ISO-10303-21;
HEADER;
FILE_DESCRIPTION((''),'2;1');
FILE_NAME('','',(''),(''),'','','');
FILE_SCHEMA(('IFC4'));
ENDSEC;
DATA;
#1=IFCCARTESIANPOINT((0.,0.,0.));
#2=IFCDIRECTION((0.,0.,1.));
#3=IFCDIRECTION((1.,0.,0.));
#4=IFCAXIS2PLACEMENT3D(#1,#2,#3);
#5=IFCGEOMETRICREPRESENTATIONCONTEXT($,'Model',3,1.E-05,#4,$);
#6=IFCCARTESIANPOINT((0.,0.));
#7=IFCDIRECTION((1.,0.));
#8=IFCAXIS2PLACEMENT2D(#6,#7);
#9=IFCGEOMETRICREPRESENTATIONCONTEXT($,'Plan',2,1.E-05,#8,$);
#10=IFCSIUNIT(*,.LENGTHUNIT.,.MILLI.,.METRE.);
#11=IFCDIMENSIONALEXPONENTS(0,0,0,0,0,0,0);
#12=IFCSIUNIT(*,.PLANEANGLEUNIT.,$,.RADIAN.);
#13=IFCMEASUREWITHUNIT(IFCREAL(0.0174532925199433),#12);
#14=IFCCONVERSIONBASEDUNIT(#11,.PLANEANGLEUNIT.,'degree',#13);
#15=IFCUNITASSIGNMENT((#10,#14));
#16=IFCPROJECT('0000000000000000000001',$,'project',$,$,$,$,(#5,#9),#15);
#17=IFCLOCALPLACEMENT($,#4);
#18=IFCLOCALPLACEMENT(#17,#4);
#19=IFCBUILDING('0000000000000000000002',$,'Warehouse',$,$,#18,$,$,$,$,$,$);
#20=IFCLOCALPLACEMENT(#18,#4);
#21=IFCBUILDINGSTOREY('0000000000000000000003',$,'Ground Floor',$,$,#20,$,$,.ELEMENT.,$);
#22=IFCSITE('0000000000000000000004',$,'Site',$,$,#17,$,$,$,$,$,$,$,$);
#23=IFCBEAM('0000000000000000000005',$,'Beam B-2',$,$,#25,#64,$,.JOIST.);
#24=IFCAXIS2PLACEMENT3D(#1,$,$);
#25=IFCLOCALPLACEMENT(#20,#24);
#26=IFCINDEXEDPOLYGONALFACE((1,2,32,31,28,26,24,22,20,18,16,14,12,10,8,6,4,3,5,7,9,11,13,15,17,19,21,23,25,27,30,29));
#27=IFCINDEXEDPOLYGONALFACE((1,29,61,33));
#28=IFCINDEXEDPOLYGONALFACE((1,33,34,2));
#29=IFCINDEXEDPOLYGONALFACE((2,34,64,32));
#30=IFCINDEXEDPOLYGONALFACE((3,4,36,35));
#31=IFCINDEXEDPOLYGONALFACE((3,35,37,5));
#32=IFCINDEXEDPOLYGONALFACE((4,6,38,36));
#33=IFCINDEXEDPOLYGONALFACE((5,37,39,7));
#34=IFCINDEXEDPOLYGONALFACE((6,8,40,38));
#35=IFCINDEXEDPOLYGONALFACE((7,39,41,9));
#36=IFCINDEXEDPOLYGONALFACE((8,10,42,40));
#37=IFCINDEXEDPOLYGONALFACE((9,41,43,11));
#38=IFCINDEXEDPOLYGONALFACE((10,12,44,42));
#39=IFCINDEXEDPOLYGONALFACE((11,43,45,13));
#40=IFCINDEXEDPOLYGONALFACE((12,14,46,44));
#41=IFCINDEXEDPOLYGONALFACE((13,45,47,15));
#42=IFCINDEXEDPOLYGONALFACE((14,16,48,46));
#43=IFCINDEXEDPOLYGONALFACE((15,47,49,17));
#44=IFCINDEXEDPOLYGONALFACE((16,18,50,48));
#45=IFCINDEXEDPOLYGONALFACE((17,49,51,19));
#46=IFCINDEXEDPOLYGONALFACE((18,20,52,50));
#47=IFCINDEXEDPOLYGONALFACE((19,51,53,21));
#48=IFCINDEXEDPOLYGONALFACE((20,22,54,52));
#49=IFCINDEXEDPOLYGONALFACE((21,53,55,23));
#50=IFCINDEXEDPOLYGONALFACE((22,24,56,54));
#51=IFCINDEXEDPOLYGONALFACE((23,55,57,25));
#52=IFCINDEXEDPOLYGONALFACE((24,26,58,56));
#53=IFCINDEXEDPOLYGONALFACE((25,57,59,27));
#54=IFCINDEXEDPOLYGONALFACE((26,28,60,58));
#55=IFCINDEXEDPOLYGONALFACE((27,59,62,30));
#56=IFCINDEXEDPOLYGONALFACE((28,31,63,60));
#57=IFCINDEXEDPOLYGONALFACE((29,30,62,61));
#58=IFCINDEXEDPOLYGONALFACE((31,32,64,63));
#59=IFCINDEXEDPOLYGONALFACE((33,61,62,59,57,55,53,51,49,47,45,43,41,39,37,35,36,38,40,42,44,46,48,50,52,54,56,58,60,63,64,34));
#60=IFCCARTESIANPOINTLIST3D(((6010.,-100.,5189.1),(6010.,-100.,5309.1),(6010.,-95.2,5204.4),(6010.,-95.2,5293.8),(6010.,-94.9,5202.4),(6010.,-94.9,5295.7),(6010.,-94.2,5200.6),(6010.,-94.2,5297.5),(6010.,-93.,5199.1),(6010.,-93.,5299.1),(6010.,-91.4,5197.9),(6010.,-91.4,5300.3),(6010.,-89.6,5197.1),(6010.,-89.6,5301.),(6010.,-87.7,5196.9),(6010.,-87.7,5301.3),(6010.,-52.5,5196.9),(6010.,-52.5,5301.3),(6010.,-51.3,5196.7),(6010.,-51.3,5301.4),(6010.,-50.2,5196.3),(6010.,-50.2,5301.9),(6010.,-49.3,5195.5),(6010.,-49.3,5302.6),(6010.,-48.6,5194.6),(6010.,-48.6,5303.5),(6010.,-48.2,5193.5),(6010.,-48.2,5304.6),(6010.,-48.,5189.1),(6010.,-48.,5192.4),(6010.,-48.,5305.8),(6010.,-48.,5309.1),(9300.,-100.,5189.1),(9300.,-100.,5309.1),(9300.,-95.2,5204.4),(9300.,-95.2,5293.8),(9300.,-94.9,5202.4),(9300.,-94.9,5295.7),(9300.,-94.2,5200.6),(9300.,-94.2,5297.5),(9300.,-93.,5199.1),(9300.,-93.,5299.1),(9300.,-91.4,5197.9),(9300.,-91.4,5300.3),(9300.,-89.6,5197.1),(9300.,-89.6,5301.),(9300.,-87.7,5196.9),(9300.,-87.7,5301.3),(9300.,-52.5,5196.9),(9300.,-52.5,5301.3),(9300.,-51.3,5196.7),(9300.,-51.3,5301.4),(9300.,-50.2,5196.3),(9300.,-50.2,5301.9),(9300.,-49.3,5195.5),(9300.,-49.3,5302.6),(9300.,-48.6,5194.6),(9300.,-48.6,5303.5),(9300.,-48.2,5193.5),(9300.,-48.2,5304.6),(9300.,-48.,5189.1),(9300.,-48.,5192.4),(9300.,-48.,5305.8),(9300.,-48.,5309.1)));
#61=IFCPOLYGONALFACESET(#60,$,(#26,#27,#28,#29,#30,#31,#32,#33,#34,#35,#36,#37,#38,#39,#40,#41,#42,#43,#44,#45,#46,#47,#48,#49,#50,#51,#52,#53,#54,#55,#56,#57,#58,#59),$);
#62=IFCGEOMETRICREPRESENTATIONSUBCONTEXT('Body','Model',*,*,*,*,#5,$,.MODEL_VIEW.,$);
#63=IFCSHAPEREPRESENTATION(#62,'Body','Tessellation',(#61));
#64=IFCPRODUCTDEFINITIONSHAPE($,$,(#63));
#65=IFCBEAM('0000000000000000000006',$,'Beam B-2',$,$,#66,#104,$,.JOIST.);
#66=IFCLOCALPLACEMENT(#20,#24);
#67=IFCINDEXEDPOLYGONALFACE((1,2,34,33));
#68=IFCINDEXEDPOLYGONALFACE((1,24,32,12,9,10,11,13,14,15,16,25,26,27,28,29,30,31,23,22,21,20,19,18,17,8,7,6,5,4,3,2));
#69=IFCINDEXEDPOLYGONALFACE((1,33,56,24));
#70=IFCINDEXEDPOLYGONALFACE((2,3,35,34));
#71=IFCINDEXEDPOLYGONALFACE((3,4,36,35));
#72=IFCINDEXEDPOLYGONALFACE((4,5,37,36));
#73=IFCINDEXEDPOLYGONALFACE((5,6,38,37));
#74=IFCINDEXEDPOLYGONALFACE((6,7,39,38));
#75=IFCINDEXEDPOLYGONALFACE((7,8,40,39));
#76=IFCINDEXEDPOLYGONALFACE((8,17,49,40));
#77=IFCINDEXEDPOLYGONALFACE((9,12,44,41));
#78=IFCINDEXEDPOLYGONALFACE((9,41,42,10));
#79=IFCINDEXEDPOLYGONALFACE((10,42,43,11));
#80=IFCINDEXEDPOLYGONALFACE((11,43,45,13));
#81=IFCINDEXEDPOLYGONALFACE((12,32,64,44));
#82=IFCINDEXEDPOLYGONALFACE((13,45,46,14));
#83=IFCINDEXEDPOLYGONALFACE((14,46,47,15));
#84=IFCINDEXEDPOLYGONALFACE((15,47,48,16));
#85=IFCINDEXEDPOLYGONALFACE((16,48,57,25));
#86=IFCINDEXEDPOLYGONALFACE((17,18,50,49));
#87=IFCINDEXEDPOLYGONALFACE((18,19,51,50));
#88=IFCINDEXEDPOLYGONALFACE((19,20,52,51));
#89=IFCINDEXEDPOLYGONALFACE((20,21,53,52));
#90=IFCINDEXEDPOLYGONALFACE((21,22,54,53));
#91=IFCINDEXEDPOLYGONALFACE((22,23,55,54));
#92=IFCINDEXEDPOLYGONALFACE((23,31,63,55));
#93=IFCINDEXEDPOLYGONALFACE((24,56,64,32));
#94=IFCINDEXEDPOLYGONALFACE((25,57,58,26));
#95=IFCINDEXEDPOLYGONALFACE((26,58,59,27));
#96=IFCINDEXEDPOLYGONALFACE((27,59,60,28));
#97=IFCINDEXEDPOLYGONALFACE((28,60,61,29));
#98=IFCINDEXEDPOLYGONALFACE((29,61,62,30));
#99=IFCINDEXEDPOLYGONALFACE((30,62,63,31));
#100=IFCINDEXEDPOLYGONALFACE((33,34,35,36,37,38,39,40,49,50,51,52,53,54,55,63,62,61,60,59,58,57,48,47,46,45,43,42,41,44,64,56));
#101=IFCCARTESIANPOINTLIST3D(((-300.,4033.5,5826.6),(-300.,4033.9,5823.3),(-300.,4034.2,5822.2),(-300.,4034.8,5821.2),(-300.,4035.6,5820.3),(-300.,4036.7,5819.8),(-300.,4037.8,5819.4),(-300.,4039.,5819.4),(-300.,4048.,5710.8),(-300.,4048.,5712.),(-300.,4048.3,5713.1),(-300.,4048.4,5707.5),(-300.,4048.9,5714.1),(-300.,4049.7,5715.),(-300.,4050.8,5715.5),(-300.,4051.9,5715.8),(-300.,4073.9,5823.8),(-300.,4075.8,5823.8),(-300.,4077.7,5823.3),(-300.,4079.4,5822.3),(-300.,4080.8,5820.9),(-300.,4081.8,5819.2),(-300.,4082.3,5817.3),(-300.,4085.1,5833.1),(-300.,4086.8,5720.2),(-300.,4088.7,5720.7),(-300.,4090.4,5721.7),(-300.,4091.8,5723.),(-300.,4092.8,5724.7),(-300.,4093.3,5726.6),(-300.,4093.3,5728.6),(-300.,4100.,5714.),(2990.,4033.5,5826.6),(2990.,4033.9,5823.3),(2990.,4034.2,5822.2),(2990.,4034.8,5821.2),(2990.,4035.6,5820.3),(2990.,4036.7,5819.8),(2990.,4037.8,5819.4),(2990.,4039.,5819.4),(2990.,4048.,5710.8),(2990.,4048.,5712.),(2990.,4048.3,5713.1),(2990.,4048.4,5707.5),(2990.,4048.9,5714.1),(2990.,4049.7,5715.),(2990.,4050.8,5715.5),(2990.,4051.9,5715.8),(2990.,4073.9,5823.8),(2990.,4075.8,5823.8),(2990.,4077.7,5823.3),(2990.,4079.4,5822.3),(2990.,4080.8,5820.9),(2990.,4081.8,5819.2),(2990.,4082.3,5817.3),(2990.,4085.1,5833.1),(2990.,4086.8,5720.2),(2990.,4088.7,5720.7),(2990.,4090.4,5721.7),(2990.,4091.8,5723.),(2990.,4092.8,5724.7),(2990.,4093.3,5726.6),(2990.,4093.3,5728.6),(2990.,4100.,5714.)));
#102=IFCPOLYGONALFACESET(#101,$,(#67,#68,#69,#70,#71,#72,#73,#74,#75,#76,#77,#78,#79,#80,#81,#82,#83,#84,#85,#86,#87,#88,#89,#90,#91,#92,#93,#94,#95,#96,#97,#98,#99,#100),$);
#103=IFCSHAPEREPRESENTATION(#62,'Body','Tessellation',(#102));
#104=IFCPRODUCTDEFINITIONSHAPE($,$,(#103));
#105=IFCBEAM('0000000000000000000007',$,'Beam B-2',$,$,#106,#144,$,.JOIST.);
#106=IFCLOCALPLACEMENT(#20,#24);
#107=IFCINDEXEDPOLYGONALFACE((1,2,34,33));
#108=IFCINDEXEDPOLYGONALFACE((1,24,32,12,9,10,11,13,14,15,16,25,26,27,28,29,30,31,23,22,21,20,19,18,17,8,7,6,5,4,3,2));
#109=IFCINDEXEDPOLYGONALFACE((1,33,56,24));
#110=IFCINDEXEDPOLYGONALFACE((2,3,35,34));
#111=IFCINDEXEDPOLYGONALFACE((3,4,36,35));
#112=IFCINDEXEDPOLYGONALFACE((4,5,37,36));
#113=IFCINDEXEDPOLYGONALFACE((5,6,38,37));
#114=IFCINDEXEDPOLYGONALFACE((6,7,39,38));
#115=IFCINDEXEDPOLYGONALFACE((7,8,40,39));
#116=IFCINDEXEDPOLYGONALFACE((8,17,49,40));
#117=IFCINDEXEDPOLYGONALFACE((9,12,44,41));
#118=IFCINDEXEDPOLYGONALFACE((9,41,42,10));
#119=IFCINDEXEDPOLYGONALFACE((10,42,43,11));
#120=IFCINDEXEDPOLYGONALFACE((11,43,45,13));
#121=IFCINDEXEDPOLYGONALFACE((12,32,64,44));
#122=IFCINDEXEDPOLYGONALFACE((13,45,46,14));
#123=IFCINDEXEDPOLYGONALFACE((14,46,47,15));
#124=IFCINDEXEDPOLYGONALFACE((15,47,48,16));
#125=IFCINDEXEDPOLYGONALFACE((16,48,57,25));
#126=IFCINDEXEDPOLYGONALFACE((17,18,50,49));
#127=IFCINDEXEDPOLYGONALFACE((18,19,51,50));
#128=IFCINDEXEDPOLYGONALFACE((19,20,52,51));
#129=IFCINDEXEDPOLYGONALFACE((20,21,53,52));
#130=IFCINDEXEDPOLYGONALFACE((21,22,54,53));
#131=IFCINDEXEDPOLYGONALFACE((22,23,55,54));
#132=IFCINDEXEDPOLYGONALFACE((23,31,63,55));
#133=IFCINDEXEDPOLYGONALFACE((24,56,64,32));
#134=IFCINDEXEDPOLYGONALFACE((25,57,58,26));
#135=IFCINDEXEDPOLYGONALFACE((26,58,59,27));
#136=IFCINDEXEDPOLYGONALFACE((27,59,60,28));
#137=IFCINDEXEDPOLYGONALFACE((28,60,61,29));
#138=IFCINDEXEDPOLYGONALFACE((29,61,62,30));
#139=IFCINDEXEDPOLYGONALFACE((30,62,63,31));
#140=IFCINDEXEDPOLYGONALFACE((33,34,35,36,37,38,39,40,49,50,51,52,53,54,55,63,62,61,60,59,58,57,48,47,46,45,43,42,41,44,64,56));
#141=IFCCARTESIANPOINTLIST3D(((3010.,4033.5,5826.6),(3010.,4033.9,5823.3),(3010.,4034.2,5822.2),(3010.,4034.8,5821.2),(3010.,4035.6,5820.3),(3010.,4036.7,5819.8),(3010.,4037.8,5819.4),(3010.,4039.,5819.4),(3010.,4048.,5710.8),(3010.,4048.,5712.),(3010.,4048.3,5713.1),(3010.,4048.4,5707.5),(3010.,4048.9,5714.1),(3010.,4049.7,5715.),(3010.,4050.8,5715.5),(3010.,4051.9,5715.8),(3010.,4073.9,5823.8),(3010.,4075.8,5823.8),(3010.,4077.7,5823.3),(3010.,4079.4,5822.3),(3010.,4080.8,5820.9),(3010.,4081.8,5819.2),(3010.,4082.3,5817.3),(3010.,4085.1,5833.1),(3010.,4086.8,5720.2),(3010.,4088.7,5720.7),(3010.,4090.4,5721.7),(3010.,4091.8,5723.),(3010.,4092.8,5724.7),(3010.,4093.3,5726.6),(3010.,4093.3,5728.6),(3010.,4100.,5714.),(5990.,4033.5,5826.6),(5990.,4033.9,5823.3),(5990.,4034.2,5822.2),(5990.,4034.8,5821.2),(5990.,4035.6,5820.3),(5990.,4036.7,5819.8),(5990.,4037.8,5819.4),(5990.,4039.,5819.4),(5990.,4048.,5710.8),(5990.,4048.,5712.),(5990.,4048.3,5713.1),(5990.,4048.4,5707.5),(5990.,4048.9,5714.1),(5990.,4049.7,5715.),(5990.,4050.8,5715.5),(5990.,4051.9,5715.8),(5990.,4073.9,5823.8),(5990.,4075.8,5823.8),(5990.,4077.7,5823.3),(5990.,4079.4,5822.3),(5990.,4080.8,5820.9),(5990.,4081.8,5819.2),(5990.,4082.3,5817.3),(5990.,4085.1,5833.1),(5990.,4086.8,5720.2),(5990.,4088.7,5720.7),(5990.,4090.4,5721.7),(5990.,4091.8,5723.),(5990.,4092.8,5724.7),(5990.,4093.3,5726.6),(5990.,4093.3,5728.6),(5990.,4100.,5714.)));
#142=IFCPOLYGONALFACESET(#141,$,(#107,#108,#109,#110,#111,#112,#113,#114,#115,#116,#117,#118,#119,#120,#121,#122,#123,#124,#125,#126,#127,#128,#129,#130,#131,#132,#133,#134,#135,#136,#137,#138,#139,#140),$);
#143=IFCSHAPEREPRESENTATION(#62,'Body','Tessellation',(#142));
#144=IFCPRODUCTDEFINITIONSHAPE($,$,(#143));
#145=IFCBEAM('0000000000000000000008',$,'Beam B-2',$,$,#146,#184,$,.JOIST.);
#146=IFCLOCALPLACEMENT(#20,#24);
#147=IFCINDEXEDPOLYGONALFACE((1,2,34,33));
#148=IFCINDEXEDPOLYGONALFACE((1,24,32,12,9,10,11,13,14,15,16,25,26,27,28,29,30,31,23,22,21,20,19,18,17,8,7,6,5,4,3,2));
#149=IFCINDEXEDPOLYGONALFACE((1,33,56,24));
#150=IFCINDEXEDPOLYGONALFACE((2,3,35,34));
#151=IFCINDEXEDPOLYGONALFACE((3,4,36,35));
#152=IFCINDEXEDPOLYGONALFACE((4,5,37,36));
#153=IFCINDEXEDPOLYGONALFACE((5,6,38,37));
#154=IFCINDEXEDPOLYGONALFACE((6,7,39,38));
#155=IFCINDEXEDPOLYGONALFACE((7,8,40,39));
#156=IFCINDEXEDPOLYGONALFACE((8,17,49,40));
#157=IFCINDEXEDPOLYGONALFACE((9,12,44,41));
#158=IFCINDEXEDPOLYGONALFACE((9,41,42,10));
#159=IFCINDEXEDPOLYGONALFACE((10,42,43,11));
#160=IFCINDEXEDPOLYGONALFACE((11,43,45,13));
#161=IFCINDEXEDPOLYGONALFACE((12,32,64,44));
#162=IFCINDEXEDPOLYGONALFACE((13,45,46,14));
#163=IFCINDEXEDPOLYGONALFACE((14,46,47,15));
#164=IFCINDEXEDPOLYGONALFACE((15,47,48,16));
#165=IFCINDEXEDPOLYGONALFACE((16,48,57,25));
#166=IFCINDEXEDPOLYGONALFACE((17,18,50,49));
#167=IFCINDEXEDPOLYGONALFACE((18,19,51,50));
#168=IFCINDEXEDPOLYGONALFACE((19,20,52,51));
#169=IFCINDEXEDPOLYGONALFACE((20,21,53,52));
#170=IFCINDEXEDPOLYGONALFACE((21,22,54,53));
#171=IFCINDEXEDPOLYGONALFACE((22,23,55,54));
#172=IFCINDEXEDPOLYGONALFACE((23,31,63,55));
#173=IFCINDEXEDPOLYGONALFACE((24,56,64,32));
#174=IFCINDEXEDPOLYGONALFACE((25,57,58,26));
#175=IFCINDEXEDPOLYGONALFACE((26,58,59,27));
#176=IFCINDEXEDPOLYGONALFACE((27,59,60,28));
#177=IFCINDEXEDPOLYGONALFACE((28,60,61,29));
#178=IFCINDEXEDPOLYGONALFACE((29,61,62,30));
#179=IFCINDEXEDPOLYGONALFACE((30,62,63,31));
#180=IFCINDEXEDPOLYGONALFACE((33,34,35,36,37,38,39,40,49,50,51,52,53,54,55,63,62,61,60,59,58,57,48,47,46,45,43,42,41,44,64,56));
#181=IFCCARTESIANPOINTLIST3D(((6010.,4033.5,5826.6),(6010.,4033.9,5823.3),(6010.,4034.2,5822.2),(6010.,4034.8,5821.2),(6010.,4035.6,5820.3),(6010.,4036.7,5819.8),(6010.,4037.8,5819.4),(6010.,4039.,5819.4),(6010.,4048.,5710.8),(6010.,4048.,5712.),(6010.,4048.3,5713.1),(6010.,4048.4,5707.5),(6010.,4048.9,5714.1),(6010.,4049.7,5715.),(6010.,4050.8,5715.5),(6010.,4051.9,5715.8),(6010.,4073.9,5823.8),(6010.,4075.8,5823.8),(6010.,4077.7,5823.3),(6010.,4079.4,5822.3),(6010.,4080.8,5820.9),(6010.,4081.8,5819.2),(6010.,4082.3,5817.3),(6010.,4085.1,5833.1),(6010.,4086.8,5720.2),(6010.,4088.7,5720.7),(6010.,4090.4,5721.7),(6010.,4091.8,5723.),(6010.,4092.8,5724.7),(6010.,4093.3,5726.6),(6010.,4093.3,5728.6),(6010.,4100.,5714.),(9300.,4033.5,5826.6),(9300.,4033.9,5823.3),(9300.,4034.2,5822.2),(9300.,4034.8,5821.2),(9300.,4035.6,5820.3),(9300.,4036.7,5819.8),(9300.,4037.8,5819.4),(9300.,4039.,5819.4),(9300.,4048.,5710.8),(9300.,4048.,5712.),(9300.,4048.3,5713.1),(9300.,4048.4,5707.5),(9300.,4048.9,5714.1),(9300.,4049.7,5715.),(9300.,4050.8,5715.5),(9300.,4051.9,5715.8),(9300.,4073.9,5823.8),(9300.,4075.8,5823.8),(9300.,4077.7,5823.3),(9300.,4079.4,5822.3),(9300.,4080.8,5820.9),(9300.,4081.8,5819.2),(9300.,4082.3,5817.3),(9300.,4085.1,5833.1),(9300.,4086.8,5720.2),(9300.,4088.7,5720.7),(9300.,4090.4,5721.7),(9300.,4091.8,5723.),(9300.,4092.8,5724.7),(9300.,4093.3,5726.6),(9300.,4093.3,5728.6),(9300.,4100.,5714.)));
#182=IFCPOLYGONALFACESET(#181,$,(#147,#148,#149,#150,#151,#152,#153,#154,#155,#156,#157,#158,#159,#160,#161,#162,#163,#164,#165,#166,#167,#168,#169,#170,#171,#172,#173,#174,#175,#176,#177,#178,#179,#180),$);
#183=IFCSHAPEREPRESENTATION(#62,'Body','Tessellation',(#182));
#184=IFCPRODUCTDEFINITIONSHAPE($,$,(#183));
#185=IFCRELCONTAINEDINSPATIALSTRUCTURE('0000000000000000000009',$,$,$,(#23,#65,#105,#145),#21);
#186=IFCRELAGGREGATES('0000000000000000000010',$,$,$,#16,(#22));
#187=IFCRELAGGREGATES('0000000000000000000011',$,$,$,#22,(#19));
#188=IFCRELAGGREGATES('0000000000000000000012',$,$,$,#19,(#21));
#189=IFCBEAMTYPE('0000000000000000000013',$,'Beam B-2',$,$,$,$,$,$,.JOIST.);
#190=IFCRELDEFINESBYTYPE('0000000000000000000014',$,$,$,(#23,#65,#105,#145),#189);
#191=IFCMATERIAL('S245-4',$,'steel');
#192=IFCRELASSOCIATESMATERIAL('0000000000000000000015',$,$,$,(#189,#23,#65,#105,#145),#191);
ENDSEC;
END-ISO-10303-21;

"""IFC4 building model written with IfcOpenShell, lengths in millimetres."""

from ifc_helpers import new_model, entity, si_unit, converted_unit, frame, origin_with_axes, origin_2d_with_axis, place, context, subcontext, project, spatial, u_section, extrude, material, material_profile, profile_set, profile_usage, type_object, element, save


model = new_model("IFC4")

# Units and contexts
model_context = context("Model", 3, precision=1e-05, world=origin_with_axes())
plan_context = context("Plan", 2, precision=1e-05, world=origin_2d_with_axis())
body_context = subcontext(model_context, "Body", "Model", "MODEL_VIEW")
ifc_project = project(units=[si_unit("LENGTHUNIT", "METRE", prefix="MILLI"), converted_unit("PLANEANGLEUNIT", "degree", entity("IfcReal", 0.0174532925199433), si_unit("PLANEANGLEUNIT", "RADIAN"), dimensions=[0, 0, 0, 0, 0, 0, 0])], contexts=[model_context, plan_context])

# Site, building, storey
site_placement = place(None, origin_with_axes())
site = spatial("IfcSite", under=ifc_project, at=site_placement, Name="Site")
building_placement = place(site_placement, origin_with_axes())
building = spatial("IfcBuilding", under=site, at=building_placement, Name="Warehouse")
storey_placement = place(building_placement, origin_with_axes())
storey = spatial("IfcBuildingStorey", under=building, at=storey_placement, Name="Ground Floor", CompositionType="ELEMENT")

# Beams
ifc_material_1 = material(Name="S245-4", Category="steel")
ifc_material_profile_1 = material_profile(ifc_material_1, u_section(Depth=120.0, FlangeWidth=52.0, WebThickness=4.8, FlangeThickness=7.8, FilletRadius=7.5, EdgeRadius=4.5, FlangeSlope=0.0))
ifc_profile_set_1 = profile_set([ifc_material_profile_1], Name="U12P_S245-4")
beam_type_1 = type_object("IfcBeamType", Name="Beam B-2", PredefinedType="JOIST", material=ifc_profile_set_1)
ifc_profile_usage_1 = profile_usage(ifc_profile_set_1, cardinal=3)
beam_1_placement = place(storey_placement, frame((6010.0, -100.0, 5189.1), z_axis=(1.0, 0.0, 0.0), x_axis=(0.0, 1.0, 0.0)))
element("IfcBeam", 1, at=beam_1_placement, inside=storey, type_object=beam_type_1, material=ifc_profile_usage_1, Name="Beam B-2", PredefinedType="JOIST", context=body_context, shape_type="SweptSolid", body=[
    extrude(u_section(Depth=120.0, FlangeWidth=52.0, WebThickness=4.8, FlangeThickness=7.8, FilletRadius=7.5, EdgeRadius=4.5, FlangeSlope=0.0), frame((26.0, 60.0, 0.0), z_axis=(0.0, 0.0, 1.0), x_axis=(1.0, 0.0, 0.0)), (0.0, 0.0, 1.0), 3290.0),
])
ifc_profile_usage_2 = profile_usage(ifc_profile_set_1, cardinal=3)
beam_2_placement = place(storey_placement, frame((2990.0, 4100.0, 5714.0), z_axis=(-1.0, 0.0, 0.0), x_axis=(0.0, -0.99228, -0.124019)))
element("IfcBeam", 2, at=beam_2_placement, inside=storey, type_object=beam_type_1, material=ifc_profile_usage_2, Name="Beam B-2", PredefinedType="JOIST", context=body_context, shape_type="SweptSolid", body=[
    extrude(u_section(Depth=120.0, FlangeWidth=52.0, WebThickness=4.8, FlangeThickness=7.8, FilletRadius=7.5, EdgeRadius=4.5, FlangeSlope=0.0), frame((26.0, 60.0, 0.0), z_axis=(0.0, 0.0, 1.0), x_axis=(1.0, 0.0, 0.0)), (0.0, 0.0, 1.0), 3290.0),
])
ifc_profile_usage_3 = profile_usage(ifc_profile_set_1, cardinal=3)
beam_3_placement = place(storey_placement, frame((5990.0, 4100.0, 5714.0), z_axis=(-1.0, 0.0, 0.0), x_axis=(0.0, -0.99228, -0.12402)))
element("IfcBeam", 3, at=beam_3_placement, inside=storey, type_object=beam_type_1, material=ifc_profile_usage_3, Name="Beam B-2", PredefinedType="JOIST", context=body_context, shape_type="SweptSolid", body=[
    extrude(u_section(Depth=120.0, FlangeWidth=52.0, WebThickness=4.8, FlangeThickness=7.8, FilletRadius=7.5, EdgeRadius=4.5, FlangeSlope=0.0), frame((26.0, 60.0, 0.0), z_axis=(0.0, 0.0, 1.0), x_axis=(1.0, 0.0, 0.0)), (0.0, 0.0, 1.0), 2980.0),
])
ifc_profile_usage_4 = profile_usage(ifc_profile_set_1, cardinal=3)
beam_4_placement = place(storey_placement, frame((9300.0, 4100.0, 5714.0), z_axis=(-1.0, 0.0, 0.0), x_axis=(0.0, -0.99228, -0.12402)))
element("IfcBeam", 4, at=beam_4_placement, inside=storey, type_object=beam_type_1, material=ifc_profile_usage_4, Name="Beam B-2", PredefinedType="JOIST", context=body_context, shape_type="SweptSolid", body=[
    extrude(u_section(Depth=120.0, FlangeWidth=52.0, WebThickness=4.8, FlangeThickness=7.8, FilletRadius=7.5, EdgeRadius=4.5, FlangeSlope=0.0), frame((26.0, 60.0, 0.0), z_axis=(0.0, 0.0, 1.0), x_axis=(1.0, 0.0, 0.0)), (0.0, 0.0, 1.0), 3290.0),
])

save(model, "model.ifc")
